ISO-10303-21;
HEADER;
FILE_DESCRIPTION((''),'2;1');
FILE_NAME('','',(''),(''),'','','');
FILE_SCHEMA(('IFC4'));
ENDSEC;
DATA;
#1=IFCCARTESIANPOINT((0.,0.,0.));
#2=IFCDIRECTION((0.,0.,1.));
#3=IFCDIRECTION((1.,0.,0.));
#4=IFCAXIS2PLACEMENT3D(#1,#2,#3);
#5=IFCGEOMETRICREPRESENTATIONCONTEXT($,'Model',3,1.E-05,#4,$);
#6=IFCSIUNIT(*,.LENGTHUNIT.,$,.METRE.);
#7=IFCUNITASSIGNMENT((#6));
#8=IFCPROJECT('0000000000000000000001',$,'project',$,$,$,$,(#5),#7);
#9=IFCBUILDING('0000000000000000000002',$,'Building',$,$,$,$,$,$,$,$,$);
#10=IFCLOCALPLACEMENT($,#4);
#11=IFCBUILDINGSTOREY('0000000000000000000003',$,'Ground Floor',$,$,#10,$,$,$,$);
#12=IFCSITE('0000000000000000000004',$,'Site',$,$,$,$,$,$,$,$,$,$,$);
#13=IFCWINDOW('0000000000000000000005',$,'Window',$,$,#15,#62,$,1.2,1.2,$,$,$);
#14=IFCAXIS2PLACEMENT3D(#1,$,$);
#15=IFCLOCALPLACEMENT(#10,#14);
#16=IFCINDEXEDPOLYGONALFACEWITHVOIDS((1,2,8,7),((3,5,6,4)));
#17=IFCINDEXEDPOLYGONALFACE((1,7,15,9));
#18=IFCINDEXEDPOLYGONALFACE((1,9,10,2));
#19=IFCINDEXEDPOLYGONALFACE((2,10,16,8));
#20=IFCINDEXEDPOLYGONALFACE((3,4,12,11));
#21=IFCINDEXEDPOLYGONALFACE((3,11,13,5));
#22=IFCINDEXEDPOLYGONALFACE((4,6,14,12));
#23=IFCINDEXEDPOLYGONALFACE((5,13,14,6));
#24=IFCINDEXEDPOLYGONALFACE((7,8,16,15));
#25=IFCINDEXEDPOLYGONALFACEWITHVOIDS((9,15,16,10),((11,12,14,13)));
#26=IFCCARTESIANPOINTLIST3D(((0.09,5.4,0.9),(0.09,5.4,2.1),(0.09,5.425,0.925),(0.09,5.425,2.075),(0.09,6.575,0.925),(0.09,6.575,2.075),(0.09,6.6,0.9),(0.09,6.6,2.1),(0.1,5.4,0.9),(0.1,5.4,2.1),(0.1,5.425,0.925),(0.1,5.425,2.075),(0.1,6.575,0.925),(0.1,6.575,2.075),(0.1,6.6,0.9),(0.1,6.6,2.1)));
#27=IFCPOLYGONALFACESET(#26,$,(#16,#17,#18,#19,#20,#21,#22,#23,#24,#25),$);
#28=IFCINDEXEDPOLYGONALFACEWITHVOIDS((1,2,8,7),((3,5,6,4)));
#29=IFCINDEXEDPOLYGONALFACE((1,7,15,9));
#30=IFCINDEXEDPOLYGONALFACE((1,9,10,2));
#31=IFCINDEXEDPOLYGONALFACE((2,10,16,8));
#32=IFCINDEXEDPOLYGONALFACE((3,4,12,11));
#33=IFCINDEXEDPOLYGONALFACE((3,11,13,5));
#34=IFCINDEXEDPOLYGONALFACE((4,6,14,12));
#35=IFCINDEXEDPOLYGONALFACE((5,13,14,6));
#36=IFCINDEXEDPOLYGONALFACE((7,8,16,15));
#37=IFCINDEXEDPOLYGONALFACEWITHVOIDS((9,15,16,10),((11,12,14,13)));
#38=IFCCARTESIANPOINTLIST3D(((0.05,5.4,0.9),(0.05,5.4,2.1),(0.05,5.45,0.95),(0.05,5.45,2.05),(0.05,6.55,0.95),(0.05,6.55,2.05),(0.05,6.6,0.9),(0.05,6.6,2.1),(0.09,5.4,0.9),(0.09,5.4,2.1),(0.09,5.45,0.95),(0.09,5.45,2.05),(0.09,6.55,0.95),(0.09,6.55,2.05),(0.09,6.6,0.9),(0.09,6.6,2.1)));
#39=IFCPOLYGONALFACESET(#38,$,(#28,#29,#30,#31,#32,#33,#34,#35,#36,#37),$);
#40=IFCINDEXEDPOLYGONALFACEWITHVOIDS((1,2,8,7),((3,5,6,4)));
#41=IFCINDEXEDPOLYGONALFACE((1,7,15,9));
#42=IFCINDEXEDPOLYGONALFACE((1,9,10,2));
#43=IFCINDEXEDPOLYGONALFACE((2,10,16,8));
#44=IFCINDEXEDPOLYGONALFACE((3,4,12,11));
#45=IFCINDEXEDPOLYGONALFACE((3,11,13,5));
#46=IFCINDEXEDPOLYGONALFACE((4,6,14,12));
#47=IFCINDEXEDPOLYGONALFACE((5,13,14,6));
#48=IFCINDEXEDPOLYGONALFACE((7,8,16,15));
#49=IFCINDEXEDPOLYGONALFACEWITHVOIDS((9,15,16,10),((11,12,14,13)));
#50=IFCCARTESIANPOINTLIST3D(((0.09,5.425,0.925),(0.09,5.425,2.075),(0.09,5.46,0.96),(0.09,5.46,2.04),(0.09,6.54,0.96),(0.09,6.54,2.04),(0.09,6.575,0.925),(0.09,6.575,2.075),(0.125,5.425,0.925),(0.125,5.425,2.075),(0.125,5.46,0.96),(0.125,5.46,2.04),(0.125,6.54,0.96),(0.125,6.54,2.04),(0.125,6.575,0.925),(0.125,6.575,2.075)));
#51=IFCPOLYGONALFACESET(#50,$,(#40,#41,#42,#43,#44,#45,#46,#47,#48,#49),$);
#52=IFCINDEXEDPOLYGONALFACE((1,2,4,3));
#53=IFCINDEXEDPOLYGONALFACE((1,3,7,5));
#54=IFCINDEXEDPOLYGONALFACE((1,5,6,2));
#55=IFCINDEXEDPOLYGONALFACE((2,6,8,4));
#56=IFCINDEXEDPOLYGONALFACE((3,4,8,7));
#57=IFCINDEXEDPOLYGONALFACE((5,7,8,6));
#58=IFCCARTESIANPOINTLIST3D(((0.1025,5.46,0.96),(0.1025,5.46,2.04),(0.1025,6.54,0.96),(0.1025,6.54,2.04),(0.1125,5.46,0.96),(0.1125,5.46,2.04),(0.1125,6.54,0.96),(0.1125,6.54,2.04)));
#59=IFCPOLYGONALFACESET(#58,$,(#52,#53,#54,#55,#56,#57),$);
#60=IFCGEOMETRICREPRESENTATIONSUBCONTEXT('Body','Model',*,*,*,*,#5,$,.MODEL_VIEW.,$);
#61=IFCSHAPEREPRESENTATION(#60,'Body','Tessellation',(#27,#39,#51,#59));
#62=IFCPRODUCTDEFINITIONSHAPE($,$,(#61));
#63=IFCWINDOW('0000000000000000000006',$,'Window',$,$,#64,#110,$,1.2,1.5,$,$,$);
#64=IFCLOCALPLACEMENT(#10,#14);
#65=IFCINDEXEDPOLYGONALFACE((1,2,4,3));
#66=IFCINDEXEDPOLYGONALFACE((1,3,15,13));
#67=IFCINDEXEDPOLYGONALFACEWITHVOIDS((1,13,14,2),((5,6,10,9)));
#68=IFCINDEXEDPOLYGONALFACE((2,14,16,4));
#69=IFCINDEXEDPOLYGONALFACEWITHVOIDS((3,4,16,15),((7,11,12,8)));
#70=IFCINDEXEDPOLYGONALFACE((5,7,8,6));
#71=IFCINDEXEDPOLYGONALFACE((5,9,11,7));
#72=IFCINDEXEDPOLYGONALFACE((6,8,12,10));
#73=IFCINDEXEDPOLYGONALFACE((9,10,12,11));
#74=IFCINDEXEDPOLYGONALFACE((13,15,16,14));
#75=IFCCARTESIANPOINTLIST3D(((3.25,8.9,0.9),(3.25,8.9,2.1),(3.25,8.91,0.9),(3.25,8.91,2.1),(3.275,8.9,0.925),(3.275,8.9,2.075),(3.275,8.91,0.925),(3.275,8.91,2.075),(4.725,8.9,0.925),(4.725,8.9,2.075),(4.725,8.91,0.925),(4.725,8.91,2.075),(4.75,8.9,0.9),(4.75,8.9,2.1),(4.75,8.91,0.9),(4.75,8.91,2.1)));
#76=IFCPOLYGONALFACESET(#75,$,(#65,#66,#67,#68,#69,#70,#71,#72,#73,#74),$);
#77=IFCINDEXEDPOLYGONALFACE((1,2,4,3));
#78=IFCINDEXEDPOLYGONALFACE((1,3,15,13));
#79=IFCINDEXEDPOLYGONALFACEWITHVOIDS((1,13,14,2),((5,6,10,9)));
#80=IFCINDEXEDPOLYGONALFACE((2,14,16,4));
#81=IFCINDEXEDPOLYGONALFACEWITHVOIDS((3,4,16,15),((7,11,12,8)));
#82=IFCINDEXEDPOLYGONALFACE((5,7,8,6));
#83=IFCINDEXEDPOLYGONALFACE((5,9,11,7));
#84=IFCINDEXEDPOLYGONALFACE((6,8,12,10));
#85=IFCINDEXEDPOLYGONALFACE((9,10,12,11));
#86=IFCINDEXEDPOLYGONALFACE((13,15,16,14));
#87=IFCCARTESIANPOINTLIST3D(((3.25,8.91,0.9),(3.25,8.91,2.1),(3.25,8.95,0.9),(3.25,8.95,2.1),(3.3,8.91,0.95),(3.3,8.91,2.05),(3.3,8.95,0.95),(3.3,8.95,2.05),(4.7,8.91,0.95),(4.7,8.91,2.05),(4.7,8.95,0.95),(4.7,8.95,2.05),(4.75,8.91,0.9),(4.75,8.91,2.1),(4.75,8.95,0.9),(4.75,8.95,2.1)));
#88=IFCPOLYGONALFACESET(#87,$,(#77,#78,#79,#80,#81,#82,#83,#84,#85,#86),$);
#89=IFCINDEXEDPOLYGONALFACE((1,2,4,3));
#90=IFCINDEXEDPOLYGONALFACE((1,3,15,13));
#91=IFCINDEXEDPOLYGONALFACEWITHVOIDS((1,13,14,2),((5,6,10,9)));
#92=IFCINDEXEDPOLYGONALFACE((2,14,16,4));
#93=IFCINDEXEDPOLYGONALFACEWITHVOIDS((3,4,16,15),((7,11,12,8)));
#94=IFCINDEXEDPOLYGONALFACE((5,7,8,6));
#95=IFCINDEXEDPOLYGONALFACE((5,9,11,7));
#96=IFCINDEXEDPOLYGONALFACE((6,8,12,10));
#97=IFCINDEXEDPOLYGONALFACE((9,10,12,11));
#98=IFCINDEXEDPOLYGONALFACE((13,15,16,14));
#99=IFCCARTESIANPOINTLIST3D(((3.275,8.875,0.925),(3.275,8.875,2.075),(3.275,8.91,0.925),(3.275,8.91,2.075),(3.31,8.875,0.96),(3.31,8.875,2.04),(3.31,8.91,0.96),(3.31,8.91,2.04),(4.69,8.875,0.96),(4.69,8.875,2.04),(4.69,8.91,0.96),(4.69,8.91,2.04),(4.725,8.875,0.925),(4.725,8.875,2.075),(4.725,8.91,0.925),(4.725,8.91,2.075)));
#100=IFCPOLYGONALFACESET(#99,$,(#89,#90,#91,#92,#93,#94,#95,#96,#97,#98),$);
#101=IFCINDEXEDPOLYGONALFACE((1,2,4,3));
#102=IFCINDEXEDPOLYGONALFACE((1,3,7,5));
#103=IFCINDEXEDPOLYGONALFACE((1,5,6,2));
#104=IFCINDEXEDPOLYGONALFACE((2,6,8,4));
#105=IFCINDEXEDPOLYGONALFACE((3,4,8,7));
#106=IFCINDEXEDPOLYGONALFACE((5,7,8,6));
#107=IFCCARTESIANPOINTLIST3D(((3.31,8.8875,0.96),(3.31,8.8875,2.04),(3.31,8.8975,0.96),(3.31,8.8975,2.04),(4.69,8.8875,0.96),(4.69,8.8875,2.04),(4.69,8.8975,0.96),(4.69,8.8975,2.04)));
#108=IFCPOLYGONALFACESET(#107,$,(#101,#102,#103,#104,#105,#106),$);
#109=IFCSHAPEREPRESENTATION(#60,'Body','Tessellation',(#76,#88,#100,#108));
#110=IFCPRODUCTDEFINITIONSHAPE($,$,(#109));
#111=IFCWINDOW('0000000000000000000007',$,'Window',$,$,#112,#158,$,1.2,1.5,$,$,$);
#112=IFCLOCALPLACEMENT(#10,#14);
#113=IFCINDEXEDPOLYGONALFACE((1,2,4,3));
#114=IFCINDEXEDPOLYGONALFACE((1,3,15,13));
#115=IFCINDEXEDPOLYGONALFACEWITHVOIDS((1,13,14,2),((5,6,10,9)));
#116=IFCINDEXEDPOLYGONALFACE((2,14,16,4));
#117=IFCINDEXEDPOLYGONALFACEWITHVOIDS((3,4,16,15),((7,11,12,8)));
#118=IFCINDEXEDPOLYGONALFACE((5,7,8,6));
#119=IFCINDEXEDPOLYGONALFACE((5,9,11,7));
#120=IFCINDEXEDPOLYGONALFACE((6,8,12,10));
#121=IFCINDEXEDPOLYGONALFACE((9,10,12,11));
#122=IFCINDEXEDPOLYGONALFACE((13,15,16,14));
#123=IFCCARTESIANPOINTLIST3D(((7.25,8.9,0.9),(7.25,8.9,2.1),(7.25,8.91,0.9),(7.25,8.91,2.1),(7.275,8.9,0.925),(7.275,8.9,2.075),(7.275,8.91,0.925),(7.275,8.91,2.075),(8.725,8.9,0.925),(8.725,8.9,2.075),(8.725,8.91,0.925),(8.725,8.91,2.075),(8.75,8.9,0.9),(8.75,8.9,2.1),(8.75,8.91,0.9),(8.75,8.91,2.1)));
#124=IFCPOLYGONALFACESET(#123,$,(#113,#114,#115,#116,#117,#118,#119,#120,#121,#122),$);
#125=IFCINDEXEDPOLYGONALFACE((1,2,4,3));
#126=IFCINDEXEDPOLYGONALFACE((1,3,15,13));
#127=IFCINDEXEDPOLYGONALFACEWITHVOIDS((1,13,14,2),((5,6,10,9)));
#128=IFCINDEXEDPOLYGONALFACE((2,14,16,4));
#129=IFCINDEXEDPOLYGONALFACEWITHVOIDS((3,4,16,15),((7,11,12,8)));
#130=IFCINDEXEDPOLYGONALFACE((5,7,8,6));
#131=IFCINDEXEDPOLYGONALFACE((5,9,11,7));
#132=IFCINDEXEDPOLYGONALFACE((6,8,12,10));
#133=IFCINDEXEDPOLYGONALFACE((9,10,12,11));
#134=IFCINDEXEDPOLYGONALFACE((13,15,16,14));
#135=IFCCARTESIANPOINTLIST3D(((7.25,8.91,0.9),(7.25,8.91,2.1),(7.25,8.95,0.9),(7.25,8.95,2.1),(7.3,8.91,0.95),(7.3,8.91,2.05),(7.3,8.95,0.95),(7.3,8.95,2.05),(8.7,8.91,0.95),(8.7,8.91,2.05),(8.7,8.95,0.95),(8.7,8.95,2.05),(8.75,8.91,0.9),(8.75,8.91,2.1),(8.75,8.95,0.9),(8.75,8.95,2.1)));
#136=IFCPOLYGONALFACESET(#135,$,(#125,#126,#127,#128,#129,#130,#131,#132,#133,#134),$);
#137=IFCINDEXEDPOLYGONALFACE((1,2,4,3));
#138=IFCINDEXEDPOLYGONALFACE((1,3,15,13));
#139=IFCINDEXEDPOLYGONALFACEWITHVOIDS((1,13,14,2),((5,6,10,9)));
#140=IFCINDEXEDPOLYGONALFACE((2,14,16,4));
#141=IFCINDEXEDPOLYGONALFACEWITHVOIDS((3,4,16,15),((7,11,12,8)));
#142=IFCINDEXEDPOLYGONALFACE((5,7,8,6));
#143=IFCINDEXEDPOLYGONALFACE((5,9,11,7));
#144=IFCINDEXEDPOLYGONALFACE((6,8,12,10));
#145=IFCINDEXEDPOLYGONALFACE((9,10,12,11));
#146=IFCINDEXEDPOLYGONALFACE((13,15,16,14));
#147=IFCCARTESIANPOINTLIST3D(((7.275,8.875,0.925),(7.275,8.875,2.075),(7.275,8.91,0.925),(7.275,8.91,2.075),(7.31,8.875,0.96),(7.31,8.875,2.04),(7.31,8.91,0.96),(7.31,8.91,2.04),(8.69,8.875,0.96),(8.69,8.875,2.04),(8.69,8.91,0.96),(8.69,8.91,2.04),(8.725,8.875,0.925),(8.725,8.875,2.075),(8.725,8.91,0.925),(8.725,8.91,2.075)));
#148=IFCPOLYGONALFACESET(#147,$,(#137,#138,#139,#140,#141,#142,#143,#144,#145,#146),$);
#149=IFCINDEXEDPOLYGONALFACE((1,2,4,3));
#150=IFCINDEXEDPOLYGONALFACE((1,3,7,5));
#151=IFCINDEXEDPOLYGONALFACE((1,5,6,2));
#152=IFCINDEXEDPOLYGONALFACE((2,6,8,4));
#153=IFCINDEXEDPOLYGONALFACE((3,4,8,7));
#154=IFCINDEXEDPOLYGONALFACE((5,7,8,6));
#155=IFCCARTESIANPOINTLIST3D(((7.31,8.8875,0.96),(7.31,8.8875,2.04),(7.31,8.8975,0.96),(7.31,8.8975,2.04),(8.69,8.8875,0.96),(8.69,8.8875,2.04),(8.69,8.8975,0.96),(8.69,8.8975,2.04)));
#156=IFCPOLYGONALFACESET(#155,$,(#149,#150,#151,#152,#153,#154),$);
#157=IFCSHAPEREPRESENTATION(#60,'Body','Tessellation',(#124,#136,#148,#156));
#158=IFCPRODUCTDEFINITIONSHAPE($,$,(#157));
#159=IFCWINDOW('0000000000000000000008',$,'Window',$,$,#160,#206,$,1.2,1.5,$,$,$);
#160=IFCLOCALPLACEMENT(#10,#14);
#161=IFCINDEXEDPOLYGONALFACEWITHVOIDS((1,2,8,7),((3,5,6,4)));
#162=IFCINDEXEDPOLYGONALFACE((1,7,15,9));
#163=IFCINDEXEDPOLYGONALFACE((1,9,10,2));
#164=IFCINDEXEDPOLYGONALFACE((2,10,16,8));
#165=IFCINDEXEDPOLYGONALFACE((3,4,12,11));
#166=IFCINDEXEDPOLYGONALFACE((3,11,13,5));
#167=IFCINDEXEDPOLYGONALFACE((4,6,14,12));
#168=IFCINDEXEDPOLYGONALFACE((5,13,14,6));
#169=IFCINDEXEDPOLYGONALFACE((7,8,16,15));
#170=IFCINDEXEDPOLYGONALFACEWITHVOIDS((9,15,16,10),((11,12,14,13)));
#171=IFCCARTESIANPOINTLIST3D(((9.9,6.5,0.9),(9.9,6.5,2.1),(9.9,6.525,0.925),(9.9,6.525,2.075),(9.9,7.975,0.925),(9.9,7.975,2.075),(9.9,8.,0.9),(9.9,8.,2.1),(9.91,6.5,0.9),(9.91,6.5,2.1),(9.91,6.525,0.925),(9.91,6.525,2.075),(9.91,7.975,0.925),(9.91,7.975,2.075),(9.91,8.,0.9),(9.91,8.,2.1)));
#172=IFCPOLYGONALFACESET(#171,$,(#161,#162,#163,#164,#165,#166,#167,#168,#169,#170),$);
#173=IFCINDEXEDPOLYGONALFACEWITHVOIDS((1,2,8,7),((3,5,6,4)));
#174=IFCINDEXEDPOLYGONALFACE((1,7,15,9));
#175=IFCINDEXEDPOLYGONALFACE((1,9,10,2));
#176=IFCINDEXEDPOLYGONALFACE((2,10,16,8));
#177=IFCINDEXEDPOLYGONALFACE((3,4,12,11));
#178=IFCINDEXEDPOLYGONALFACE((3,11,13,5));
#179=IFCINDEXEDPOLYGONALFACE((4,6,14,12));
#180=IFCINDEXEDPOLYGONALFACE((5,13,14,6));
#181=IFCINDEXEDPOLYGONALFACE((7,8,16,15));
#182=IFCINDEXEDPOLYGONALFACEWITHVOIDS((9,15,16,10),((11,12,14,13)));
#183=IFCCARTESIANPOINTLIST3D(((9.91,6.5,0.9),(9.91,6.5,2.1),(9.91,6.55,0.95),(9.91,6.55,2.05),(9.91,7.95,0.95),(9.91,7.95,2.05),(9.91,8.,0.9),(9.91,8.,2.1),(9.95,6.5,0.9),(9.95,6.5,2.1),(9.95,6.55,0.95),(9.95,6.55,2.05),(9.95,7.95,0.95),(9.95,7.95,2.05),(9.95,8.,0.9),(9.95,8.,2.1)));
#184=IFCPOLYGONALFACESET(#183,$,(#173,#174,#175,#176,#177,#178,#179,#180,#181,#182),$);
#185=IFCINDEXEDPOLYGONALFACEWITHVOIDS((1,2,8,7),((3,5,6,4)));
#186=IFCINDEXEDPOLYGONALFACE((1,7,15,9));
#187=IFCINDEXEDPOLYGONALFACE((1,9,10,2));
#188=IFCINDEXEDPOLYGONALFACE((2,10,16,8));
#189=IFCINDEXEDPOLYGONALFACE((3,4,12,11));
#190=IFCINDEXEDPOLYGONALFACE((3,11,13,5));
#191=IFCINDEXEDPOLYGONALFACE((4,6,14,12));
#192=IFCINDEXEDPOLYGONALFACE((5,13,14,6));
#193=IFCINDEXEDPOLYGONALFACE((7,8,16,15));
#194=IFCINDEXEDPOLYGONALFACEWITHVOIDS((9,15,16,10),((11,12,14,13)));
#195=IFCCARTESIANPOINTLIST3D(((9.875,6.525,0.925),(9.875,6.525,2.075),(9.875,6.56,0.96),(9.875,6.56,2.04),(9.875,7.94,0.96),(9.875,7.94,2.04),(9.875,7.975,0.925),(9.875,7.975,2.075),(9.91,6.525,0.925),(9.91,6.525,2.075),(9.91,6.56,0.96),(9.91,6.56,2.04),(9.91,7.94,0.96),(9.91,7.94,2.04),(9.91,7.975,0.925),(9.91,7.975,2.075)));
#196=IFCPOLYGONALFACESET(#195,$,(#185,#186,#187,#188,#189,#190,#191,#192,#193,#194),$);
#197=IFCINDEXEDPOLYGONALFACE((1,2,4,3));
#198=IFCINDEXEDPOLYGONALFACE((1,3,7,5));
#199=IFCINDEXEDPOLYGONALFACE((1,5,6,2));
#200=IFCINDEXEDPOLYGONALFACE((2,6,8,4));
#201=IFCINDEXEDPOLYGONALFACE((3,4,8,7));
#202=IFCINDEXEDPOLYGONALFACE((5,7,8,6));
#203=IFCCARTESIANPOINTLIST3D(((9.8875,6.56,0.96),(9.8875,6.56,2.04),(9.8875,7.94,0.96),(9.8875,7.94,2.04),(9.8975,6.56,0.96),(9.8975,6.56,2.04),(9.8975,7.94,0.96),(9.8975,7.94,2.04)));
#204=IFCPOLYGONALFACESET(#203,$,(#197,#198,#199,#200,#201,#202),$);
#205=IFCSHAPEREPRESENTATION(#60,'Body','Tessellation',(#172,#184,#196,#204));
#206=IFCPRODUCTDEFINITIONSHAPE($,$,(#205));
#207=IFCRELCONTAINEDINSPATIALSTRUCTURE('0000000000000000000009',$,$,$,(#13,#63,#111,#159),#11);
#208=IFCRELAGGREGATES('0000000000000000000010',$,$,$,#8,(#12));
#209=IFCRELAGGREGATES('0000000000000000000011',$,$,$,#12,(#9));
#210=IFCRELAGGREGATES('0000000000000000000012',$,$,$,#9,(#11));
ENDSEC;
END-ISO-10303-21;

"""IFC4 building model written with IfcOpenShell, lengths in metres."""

from ifc_helpers import new_model, si_unit, frame, origin_with_axes, place, context, subcontext, project, spatial, line, indexed_curve, outline, extrude, element, save


model = new_model("IFC4")

# Units and contexts
model_context = context("Model", 3, precision=1e-05, world=origin_with_axes())
body_context = subcontext(model_context, "Body", "Model", "MODEL_VIEW")
ifc_project = project(units=[si_unit("LENGTHUNIT", "METRE")], contexts=[model_context])

# Site, building, storey
site = spatial("IfcSite", under=ifc_project, Name="Site")
building = spatial("IfcBuilding", under=site, Name="Building")
storey_placement = place(None, origin_with_axes())
storey = spatial("IfcBuildingStorey", under=building, at=storey_placement, Name="Ground Floor")

# Windows
window_1_placement = place(storey_placement, frame((0.0, 6.6, 0.9), z_axis=(0.0, 0.0, 1.0), x_axis=(0.0, -1.0, 0.0)))
element("IfcWindow", 1, at=window_1_placement, inside=storey, Name="Window", OverallHeight=1.2, OverallWidth=1.2, context=body_context, shape_type="SweptSolid", body=[
    extrude(outline(indexed_curve([(0.0, 0.0), (1.2, 0.0), (1.2, 1.2), (0.0, 1.2)], segments=[line(1, 2, 3, 4, 1)]), holes=[indexed_curve([(0.025, 0.025), (1.175, 0.025), (1.175, 1.175), (0.025, 1.175)], segments=[line(1, 2, 3, 4, 1)])]), frame((0.0, 0.09, 0.0), z_axis=(0.0, -1.0, 0.0), x_axis=(1.0, 0.0, 0.0)), (0.0, 0.0, -1.0), 0.01),
    extrude(outline(indexed_curve([(0.0, 0.0), (1.2, 0.0), (1.2, 1.2), (0.0, 1.2)], segments=[line(1, 2, 3, 4, 1)]), holes=[indexed_curve([(0.05, 0.05), (1.15, 0.05), (1.15, 1.15), (0.05, 1.15)], segments=[line(1, 2, 3, 4, 1)])]), frame((0.0, 0.05, 0.0), z_axis=(0.0, -1.0, 0.0), x_axis=(1.0, 0.0, 0.0)), (0.0, 0.0, -1.0), 0.04),
    extrude(outline(indexed_curve([(0.0, 0.0), (1.15, 0.0), (1.15, 1.15), (0.0, 1.15)], segments=[line(1, 2, 3, 4, 1)]), holes=[indexed_curve([(0.035, 0.035), (1.115, 0.035), (1.115, 1.115), (0.035, 1.115)], segments=[line(1, 2, 3, 4, 1)])]), frame((0.025, 0.09, 0.025), z_axis=(0.0, -1.0, 0.0), x_axis=(1.0, 0.0, 0.0)), (0.0, 0.0, -1.0), 0.035),
    extrude(outline(indexed_curve([(0.035, 0.035), (1.115, 0.035), (1.115, 1.115), (0.035, 1.115)], segments=[line(1, 2, 3, 4, 1)])), frame((0.025, 0.1025, 0.025), z_axis=(0.0, -1.0, 0.0), x_axis=(1.0, 0.0, 0.0)), (0.0, 0.0, -1.0), 0.01),
])
for number, where, z_axis, x_axis, name in (
    (2, (4.75, 9.0, 0.9), (0.0, 0.0, 1.0), (-1.0, 0.0, 0.0), "Window"),
    (3, (8.75, 9.0, 0.9), (0.0, 0.0, 1.0), (-1.0, 0.0, 0.0), "Window"),
    (4, (10.0, 6.5, 0.9), (0.0, 0.0, 1.0), (0.0, 1.0, 0.0), "Window"),
):
    element("IfcWindow", number, at=place(storey_placement, frame(where, z_axis=z_axis, x_axis=x_axis)), inside=storey, Name=name, OverallHeight=1.2, OverallWidth=1.5, context=body_context, shape_type="SweptSolid", body=[
        extrude(outline(indexed_curve([(0.0, 0.0), (1.5, 0.0), (1.5, 1.2), (0.0, 1.2)], segments=[line(1, 2, 3, 4, 1)]), holes=[indexed_curve([(0.025, 0.025), (1.475, 0.025), (1.475, 1.175), (0.025, 1.175)], segments=[line(1, 2, 3, 4, 1)])]), frame((0.0, 0.09, 0.0), z_axis=(0.0, -1.0, 0.0), x_axis=(1.0, 0.0, 0.0)), (0.0, 0.0, -1.0), 0.01),
        extrude(outline(indexed_curve([(0.0, 0.0), (1.5, 0.0), (1.5, 1.2), (0.0, 1.2)], segments=[line(1, 2, 3, 4, 1)]), holes=[indexed_curve([(0.05, 0.05), (1.45, 0.05), (1.45, 1.15), (0.05, 1.15)], segments=[line(1, 2, 3, 4, 1)])]), frame((0.0, 0.05, 0.0), z_axis=(0.0, -1.0, 0.0), x_axis=(1.0, 0.0, 0.0)), (0.0, 0.0, -1.0), 0.04),
        extrude(outline(indexed_curve([(0.0, 0.0), (1.45, 0.0), (1.45, 1.15), (0.0, 1.15)], segments=[line(1, 2, 3, 4, 1)]), holes=[indexed_curve([(0.035, 0.035), (1.415, 0.035), (1.415, 1.115), (0.035, 1.115)], segments=[line(1, 2, 3, 4, 1)])]), frame((0.025, 0.09, 0.025), z_axis=(0.0, -1.0, 0.0), x_axis=(1.0, 0.0, 0.0)), (0.0, 0.0, -1.0), 0.035),
        extrude(outline(indexed_curve([(0.035, 0.035), (1.415, 0.035), (1.415, 1.115), (0.035, 1.115)], segments=[line(1, 2, 3, 4, 1)])), frame((0.025, 0.1025, 0.025), z_axis=(0.0, -1.0, 0.0), x_axis=(1.0, 0.0, 0.0)), (0.0, 0.0, -1.0), 0.01),
    ])

save(model, "model.ifc")
